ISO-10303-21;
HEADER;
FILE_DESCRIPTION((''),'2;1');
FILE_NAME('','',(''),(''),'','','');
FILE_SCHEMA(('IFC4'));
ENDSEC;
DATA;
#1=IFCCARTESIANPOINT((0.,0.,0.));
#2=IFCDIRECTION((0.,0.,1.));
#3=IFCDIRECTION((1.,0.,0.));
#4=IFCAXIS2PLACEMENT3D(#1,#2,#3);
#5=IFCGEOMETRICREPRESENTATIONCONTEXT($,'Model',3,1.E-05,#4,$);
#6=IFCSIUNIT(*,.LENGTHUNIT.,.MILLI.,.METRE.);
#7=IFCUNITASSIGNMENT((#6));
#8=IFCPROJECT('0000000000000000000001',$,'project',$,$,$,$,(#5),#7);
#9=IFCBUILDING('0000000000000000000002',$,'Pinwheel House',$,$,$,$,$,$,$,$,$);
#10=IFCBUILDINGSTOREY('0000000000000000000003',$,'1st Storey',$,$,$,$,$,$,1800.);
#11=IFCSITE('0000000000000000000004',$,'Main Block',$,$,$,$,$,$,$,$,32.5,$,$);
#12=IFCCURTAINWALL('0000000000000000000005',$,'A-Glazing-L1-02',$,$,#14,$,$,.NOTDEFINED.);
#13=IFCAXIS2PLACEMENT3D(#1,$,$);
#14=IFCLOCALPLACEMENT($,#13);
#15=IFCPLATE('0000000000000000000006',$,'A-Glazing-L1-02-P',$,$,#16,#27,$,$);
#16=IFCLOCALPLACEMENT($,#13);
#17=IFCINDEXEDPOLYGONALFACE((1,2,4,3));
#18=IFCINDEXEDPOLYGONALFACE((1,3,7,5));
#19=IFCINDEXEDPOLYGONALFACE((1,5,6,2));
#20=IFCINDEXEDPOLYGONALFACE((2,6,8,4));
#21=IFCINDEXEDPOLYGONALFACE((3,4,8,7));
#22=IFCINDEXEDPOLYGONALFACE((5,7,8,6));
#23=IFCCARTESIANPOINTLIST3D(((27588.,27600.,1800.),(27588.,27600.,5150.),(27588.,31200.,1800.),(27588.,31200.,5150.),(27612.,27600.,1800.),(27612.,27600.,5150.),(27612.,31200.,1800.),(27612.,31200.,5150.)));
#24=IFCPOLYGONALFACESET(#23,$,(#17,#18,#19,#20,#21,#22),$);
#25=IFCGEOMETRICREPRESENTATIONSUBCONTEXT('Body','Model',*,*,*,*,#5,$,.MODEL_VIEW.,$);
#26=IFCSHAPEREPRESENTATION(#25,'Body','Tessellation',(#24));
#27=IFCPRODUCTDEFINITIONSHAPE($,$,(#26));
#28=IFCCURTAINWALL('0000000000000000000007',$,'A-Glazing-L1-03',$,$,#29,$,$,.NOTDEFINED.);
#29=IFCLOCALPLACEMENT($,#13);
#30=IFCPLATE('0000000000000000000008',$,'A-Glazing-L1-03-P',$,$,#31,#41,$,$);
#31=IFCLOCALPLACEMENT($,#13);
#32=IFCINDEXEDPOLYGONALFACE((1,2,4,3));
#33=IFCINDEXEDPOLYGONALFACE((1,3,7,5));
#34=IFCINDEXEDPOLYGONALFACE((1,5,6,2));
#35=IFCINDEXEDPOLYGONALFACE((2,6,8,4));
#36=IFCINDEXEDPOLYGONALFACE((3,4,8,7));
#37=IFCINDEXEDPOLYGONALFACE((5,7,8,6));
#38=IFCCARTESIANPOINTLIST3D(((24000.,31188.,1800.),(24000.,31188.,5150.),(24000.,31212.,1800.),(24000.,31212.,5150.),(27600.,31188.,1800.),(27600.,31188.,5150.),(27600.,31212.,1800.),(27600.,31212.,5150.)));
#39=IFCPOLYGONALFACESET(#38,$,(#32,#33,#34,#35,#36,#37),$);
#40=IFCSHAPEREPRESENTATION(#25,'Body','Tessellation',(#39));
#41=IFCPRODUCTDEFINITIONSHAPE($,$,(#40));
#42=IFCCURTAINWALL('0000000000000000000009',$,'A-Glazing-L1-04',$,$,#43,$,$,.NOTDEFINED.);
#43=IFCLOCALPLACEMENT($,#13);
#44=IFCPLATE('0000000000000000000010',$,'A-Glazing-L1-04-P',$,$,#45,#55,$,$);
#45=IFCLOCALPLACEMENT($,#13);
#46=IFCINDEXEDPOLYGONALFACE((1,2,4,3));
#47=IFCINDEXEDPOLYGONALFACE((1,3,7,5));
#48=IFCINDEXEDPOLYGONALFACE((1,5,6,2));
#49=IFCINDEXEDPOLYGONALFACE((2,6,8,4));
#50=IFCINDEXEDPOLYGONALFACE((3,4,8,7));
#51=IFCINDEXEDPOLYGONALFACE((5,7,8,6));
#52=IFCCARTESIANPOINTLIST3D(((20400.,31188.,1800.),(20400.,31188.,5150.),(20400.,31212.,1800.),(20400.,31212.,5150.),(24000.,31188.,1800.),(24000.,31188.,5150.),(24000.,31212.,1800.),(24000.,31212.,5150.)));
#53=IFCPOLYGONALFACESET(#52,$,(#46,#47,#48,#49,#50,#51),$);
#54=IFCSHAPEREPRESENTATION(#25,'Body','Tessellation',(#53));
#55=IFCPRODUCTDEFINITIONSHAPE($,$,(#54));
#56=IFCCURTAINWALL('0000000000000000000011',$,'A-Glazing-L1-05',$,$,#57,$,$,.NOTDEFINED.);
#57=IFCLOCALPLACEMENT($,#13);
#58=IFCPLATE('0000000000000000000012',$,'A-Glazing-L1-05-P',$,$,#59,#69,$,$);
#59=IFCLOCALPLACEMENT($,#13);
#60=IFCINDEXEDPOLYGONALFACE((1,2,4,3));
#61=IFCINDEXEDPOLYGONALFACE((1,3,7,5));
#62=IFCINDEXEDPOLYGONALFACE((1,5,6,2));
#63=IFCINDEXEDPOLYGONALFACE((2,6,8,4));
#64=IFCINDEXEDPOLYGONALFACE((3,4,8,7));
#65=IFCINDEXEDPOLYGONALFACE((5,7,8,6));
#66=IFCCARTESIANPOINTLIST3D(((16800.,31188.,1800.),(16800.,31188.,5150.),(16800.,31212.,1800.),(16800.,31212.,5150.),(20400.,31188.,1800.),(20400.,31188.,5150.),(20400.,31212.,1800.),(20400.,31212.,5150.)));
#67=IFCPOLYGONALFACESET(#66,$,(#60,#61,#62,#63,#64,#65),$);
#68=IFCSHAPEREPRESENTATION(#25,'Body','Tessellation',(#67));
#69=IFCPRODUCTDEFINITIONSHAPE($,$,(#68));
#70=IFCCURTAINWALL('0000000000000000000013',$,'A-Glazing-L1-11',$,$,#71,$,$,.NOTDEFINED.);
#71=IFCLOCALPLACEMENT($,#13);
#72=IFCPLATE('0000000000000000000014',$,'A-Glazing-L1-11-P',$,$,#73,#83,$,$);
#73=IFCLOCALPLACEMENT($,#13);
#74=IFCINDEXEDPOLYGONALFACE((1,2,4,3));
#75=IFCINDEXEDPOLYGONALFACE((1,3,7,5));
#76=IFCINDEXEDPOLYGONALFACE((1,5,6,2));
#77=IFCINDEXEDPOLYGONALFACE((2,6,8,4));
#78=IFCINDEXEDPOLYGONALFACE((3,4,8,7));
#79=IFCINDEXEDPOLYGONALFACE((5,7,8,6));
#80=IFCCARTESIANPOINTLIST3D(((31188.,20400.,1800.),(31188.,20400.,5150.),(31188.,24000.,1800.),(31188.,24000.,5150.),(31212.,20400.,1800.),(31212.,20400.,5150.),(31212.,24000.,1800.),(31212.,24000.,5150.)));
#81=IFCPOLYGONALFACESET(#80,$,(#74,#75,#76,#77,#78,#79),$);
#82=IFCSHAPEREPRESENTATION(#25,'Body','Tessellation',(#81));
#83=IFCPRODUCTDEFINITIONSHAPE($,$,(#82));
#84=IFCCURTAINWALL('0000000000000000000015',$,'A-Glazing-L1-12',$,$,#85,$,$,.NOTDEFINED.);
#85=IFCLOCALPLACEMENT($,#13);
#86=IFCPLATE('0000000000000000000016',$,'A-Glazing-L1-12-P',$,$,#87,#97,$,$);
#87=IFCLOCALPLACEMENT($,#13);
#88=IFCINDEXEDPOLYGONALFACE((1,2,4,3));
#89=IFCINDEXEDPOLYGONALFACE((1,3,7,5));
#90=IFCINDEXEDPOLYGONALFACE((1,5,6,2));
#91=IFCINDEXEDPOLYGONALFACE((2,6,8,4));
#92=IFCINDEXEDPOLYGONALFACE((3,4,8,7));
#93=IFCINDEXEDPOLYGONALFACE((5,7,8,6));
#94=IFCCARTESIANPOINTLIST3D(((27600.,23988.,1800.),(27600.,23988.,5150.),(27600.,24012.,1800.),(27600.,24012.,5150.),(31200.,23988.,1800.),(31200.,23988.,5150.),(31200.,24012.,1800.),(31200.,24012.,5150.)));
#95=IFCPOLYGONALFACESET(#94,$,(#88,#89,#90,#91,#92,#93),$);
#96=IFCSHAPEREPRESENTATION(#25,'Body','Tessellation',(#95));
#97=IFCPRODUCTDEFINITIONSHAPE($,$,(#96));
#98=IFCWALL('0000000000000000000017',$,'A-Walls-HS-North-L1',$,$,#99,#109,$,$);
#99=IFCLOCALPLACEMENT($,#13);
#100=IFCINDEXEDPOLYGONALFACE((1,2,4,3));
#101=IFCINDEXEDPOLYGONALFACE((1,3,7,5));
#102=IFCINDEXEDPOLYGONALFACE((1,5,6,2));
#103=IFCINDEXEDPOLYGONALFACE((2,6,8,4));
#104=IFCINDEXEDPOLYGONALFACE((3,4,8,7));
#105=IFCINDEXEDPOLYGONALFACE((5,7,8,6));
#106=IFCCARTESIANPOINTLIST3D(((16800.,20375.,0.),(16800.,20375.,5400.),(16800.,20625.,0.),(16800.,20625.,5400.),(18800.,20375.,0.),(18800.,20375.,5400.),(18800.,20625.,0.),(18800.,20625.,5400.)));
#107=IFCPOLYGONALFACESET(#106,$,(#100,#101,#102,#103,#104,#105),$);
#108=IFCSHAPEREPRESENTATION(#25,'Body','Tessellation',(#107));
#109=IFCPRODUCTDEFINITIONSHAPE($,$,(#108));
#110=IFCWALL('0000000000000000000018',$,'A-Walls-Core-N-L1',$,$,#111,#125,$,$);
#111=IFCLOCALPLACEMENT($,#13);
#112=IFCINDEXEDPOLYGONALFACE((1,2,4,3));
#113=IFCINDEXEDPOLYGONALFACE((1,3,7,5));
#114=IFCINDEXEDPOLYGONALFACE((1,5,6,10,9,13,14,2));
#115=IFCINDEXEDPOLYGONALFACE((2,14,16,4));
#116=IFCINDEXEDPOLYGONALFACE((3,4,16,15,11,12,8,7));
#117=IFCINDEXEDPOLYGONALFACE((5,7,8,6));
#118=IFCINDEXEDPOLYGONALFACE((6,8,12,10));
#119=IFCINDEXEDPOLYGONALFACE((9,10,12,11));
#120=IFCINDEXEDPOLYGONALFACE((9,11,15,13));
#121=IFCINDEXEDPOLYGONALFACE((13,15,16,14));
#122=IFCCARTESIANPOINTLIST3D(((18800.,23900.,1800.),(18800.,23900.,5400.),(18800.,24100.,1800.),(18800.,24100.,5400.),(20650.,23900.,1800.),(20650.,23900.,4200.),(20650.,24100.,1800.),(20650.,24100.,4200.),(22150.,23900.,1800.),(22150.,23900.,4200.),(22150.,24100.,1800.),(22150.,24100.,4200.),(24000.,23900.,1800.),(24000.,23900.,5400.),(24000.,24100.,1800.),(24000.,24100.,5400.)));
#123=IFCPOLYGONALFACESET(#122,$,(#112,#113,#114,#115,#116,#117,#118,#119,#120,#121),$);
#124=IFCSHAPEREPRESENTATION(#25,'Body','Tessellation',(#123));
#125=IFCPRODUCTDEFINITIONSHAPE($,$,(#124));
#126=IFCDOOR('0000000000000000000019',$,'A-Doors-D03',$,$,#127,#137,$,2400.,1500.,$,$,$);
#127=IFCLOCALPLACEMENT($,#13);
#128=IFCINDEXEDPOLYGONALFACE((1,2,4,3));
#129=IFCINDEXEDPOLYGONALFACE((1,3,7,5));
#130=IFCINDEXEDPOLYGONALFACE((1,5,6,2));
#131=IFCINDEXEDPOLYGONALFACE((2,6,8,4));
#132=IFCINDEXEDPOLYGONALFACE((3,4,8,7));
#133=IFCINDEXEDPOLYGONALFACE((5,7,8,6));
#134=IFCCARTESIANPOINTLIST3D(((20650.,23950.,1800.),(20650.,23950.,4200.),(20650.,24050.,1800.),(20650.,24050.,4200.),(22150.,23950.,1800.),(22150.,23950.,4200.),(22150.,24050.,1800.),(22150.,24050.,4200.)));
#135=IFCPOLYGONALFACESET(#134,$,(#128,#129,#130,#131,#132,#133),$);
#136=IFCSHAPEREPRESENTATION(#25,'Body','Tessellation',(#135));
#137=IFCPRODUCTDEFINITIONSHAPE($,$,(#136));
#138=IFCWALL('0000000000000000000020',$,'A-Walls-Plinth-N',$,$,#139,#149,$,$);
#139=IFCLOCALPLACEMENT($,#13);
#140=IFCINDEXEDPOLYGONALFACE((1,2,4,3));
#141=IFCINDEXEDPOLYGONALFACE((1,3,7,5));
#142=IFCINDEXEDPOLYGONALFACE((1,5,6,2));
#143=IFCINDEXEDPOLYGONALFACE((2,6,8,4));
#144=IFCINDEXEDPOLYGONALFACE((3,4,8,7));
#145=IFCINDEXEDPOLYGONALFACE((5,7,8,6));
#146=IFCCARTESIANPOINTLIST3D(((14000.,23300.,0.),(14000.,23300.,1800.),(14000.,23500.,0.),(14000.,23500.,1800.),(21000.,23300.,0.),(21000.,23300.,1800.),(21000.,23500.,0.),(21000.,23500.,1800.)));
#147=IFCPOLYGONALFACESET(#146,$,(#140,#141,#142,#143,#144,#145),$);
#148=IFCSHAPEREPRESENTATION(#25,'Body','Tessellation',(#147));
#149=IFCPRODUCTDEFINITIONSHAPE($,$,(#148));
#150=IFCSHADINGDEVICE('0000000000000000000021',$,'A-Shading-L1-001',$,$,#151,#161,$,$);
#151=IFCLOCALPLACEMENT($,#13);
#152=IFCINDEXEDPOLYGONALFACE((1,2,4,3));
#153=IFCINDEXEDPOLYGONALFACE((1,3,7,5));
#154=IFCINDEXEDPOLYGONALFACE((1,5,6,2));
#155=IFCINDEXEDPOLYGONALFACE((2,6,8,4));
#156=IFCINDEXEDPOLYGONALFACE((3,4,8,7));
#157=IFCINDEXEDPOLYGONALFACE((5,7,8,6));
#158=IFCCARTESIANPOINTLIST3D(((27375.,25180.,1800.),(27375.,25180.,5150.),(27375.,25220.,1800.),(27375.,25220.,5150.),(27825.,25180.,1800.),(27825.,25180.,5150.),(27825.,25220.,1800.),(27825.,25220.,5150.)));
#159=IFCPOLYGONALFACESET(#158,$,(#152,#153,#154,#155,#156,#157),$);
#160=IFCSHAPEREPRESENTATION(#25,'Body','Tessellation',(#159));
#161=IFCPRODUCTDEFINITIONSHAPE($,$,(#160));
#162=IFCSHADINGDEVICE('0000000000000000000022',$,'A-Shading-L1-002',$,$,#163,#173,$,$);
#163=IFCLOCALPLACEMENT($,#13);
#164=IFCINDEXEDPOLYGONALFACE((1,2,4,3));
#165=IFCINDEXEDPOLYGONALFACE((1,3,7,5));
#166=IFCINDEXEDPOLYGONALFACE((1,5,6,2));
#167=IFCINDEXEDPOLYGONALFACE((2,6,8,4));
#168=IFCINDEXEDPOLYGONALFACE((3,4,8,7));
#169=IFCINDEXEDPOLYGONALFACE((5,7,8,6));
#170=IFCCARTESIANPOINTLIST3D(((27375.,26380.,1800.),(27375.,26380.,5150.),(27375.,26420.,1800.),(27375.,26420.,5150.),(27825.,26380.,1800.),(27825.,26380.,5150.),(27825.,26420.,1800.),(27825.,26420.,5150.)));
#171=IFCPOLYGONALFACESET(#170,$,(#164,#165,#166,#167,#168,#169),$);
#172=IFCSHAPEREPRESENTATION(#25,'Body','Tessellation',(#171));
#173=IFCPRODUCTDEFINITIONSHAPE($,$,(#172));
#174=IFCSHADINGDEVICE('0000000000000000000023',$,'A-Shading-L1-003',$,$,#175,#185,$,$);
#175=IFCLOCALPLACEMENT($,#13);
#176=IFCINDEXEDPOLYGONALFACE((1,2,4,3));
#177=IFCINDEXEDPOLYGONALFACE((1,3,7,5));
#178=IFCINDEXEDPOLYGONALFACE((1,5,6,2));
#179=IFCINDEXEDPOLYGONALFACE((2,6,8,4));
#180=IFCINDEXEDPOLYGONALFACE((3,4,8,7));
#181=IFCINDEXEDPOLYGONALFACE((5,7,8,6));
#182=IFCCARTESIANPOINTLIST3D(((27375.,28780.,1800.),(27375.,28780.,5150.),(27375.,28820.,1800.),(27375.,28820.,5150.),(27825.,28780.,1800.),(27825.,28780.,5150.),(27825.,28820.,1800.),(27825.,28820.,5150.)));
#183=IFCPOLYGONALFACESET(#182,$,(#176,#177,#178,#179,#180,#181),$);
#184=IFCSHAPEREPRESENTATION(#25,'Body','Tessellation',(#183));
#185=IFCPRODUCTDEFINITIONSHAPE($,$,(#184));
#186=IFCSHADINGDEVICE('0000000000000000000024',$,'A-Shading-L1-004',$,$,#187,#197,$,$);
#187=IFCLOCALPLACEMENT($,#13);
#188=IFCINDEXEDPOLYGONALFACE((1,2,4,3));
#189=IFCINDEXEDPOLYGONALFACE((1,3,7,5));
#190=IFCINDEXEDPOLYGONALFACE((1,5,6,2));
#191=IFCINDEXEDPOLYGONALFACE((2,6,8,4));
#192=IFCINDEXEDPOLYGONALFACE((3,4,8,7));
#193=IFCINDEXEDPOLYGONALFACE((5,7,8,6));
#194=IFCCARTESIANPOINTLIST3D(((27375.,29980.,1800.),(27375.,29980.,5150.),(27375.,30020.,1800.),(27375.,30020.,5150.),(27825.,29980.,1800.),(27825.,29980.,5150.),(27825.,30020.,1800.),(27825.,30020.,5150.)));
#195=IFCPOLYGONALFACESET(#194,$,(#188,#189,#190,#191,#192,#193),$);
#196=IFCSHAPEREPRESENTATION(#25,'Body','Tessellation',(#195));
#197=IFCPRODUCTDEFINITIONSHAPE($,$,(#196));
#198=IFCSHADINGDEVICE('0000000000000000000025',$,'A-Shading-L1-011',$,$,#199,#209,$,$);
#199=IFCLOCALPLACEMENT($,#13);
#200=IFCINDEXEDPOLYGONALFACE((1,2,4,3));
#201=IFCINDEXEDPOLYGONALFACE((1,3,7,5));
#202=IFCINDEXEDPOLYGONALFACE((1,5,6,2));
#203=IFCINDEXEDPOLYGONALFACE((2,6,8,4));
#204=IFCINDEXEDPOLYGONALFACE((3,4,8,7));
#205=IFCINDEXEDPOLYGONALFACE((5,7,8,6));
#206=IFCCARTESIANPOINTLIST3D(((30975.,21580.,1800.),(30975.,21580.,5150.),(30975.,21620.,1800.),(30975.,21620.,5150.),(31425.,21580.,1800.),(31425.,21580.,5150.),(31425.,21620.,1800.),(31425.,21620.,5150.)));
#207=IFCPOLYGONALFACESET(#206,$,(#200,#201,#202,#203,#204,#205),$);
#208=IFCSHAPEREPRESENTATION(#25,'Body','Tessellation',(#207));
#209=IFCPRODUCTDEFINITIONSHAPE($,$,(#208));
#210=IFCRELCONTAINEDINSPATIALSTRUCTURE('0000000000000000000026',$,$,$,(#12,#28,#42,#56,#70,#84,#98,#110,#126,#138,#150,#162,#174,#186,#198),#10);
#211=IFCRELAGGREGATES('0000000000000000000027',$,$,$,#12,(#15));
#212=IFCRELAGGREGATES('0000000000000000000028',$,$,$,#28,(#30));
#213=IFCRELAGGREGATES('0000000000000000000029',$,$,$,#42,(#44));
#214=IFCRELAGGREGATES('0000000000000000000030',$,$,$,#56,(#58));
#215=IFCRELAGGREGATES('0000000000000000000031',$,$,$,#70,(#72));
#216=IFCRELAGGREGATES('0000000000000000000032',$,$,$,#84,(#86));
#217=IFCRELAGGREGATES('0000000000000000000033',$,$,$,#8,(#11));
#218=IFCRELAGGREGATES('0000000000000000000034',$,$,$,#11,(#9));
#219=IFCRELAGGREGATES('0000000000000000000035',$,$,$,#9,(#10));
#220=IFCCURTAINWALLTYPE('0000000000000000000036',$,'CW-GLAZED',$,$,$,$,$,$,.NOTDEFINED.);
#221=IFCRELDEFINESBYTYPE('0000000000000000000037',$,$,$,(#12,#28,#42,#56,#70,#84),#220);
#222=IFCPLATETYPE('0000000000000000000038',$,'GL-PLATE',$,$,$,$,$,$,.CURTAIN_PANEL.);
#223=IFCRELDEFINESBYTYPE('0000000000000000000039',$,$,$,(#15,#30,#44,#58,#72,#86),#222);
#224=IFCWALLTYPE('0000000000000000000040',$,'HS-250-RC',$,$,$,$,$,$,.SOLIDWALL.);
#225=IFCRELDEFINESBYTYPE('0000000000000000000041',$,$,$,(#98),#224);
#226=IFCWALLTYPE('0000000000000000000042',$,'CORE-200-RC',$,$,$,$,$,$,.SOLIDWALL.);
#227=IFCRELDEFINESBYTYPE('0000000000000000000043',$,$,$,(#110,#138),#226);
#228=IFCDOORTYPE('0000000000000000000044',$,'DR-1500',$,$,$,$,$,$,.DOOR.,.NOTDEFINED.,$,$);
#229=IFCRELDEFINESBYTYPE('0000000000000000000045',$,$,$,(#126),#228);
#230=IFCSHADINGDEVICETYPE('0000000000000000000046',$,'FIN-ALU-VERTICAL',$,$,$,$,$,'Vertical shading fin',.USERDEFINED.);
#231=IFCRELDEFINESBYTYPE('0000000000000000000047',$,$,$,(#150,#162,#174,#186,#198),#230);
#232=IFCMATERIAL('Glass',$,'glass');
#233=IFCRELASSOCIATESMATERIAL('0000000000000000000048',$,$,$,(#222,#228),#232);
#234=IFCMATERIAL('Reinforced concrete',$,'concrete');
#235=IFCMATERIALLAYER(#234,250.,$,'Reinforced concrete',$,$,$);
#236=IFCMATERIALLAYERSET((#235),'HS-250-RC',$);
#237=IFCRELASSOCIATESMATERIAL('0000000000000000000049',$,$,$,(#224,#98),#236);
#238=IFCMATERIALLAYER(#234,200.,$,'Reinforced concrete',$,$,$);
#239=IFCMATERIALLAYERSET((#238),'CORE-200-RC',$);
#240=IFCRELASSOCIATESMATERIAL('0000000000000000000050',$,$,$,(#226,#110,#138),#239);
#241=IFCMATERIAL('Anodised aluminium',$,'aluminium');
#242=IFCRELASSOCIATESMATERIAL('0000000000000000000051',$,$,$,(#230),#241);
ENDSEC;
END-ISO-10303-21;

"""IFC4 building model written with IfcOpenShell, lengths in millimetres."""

from ifc_helpers import new_model, si_unit, frame, origin_with_axes, place, context, subcontext, project, spatial, indexed_curve, outline, extrude, material, layer, layer_set, layer_usage, type_object, element, fill, aggregate, save


model = new_model("IFC4")

# Units and contexts
model_context = context("Model", 3, precision=1e-05, world=origin_with_axes())
body_context = subcontext(model_context, "Body", "Model", "MODEL_VIEW")
ifc_project = project(units=[si_unit("LENGTHUNIT", "METRE", prefix="MILLI")], contexts=[model_context])

# Site, building, storey
site = spatial("IfcSite", under=ifc_project, Name="Main Block", RefElevation=32.5)
building = spatial("IfcBuilding", under=site, Name="Pinwheel House")
storey = spatial("IfcBuildingStorey", under=building, Name="1st Storey", Elevation=1800.0)

# Shared definitions
ifc_material_1 = material(Name="Anodised aluminium", Category="aluminium")

# Curtain walls, plates
curtain_wall_type = type_object("IfcCurtainWallType", Name="CW-GLAZED", PredefinedType="NOTDEFINED")
ifc_material_2 = material(Name="Glass", Category="glass")
plate_type = type_object("IfcPlateType", Name="GL-PLATE", PredefinedType="CURTAIN_PANEL", material=ifc_material_2)
curtain_wall_1 = element("IfcCurtainWall", 1, inside=storey, type_object=curtain_wall_type, Name="A-Glazing-L1-02", PredefinedType="NOTDEFINED")
plate_1_placement = place(None, frame((27600.0, 29400.0, 1800.0), z_axis=(0.0, 0.0, 1.0), x_axis=(0.0, 1.0, 0.0)))
plate_1 = element("IfcPlate", 2, at=plate_1_placement, type_object=plate_type, Name="A-Glazing-L1-02-P", context=body_context, shape_type="SweptSolid", body=[
    extrude(outline(indexed_curve([(-1800.0, -12.0), (1800.0, -12.0), (1800.0, 12.0), (-1800.0, 12.0)])), None, (0.0, 0.0, 1.0), 3350.0),
])
aggregate(curtain_wall_1, [plate_1])
curtain_wall_2 = element("IfcCurtainWall", 3, inside=storey, type_object=curtain_wall_type, Name="A-Glazing-L1-03", PredefinedType="NOTDEFINED")
plate_2_placement = place(None, frame((25800.0, 31200.0, 1800.0), z_axis=(0.0, 0.0, 1.0), x_axis=(-1.0, 0.0, 0.0)))
plate_2 = element("IfcPlate", 4, at=plate_2_placement, type_object=plate_type, Name="A-Glazing-L1-03-P", context=body_context, shape_type="SweptSolid", body=[
    extrude(outline(indexed_curve([(-1800.0, -12.0), (1800.0, -12.0), (1800.0, 12.0), (-1800.0, 12.0)])), None, (0.0, 0.0, 1.0), 3350.0),
])
aggregate(curtain_wall_2, [plate_2])
curtain_wall_3 = element("IfcCurtainWall", 5, inside=storey, type_object=curtain_wall_type, Name="A-Glazing-L1-04", PredefinedType="NOTDEFINED")
plate_3_placement = place(None, frame((22200.0, 31200.0, 1800.0), z_axis=(0.0, 0.0, 1.0), x_axis=(-1.0, 0.0, 0.0)))
plate_3 = element("IfcPlate", 6, at=plate_3_placement, type_object=plate_type, Name="A-Glazing-L1-04-P", context=body_context, shape_type="SweptSolid", body=[
    extrude(outline(indexed_curve([(-1800.0, -12.0), (1800.0, -12.0), (1800.0, 12.0), (-1800.0, 12.0)])), None, (0.0, 0.0, 1.0), 3350.0),
])
aggregate(curtain_wall_3, [plate_3])
curtain_wall_4 = element("IfcCurtainWall", 7, inside=storey, type_object=curtain_wall_type, Name="A-Glazing-L1-05", PredefinedType="NOTDEFINED")
plate_4_placement = place(None, frame((18600.0, 31200.0, 1800.0), z_axis=(0.0, 0.0, 1.0), x_axis=(-1.0, 0.0, 0.0)))
plate_4 = element("IfcPlate", 8, at=plate_4_placement, type_object=plate_type, Name="A-Glazing-L1-05-P", context=body_context, shape_type="SweptSolid", body=[
    extrude(outline(indexed_curve([(-1800.0, -12.0), (1800.0, -12.0), (1800.0, 12.0), (-1800.0, 12.0)])), None, (0.0, 0.0, 1.0), 3350.0),
])
aggregate(curtain_wall_4, [plate_4])
curtain_wall_5 = element("IfcCurtainWall", 9, inside=storey, type_object=curtain_wall_type, Name="A-Glazing-L1-11", PredefinedType="NOTDEFINED")
plate_5_placement = place(None, frame((31200.0, 22200.0, 1800.0), z_axis=(0.0, 0.0, 1.0), x_axis=(0.0, 1.0, 0.0)))
plate_5 = element("IfcPlate", 10, at=plate_5_placement, type_object=plate_type, Name="A-Glazing-L1-11-P", context=body_context, shape_type="SweptSolid", body=[
    extrude(outline(indexed_curve([(-1800.0, -12.0), (1800.0, -12.0), (1800.0, 12.0), (-1800.0, 12.0)])), None, (0.0, 0.0, 1.0), 3350.0),
])
aggregate(curtain_wall_5, [plate_5])
curtain_wall_6 = element("IfcCurtainWall", 11, inside=storey, type_object=curtain_wall_type, Name="A-Glazing-L1-12", PredefinedType="NOTDEFINED")
plate_6_placement = place(None, frame((29400.0, 24000.0, 1800.0), z_axis=(0.0, 0.0, 1.0), x_axis=(-1.0, 0.0, 0.0)))
plate_6 = element("IfcPlate", 12, at=plate_6_placement, type_object=plate_type, Name="A-Glazing-L1-12-P", context=body_context, shape_type="SweptSolid", body=[
    extrude(outline(indexed_curve([(-1800.0, -12.0), (1800.0, -12.0), (1800.0, 12.0), (-1800.0, 12.0)])), None, (0.0, 0.0, 1.0), 3350.0),
])
aggregate(curtain_wall_6, [plate_6])

# Wall
ifc_material_3 = material(Name="Reinforced concrete", Category="concrete")
ifc_layer_1 = layer(ifc_material_3, 250.0, Name="Reinforced concrete")
ifc_layer_set_1 = layer_set([ifc_layer_1], Name="HS-250-RC")
ifc_layer_usage_1 = layer_usage(ifc_layer_set_1, "AXIS2", "POSITIVE", 0.0)
wall_type_1 = type_object("IfcWallType", Name="HS-250-RC", PredefinedType="SOLIDWALL", material=ifc_layer_set_1)
wall_1_placement = place(None, frame((18800.0, 20625.0, 0.0), z_axis=(0.0, 0.0, 1.0), x_axis=(-1.0, 0.0, 0.0)))
element("IfcWall", 13, at=wall_1_placement, inside=storey, type_object=wall_type_1, material=ifc_layer_usage_1, Name="A-Walls-HS-North-L1", context=body_context, shape_type="SweptSolid", body=[
    extrude(outline(indexed_curve([(0.0, 0.0), (0.0, 250.0), (2000.0, 250.0), (2000.0, 0.0), (0.0, 0.0)], self_intersect=False)), origin_with_axes(), (0.0, 0.0, 1.0), 5400.0),
])

# Wall, opening, door
ifc_layer_2 = layer(ifc_material_3, 200.0, Name="Reinforced concrete")
ifc_layer_set_2 = layer_set([ifc_layer_2], Name="CORE-200-RC")
ifc_layer_usage_2 = layer_usage(ifc_layer_set_2, "AXIS2", "POSITIVE", 0.0)
wall_type_2 = type_object("IfcWallType", Name="CORE-200-RC", PredefinedType="SOLIDWALL", material=ifc_layer_set_2)
wall_2_placement = place(None, frame((18800.0, 23900.0, 1800.0), z_axis=(0.0, 0.0, 1.0), x_axis=(1.0, 0.0, 0.0)))
wall_2 = element("IfcWall", 14, at=wall_2_placement, inside=storey, type_object=wall_type_2, material=ifc_layer_usage_2, Name="A-Walls-Core-N-L1", context=body_context, shape_type="SweptSolid", body=[
    extrude(outline(indexed_curve([(0.0, 0.0), (0.0, 200.0), (5200.0, 200.0), (5200.0, 0.0), (0.0, 0.0)], self_intersect=False)), origin_with_axes(), (0.0, 0.0, 1.0), 3600.0),
])
opening_placement = place(wall_2_placement, frame((2600.0, 100.0, 0.0), z_axis=(0.0, 0.0, 1.0), x_axis=(1.0, 0.0, 0.0)))
opening = element("IfcOpeningElement", 15, at=opening_placement, cuts=wall_2, PredefinedType="OPENING", context=body_context, shape_type="SweptSolid", body=[
    extrude(outline(indexed_curve([(-750.0, -150.0), (750.0, -150.0), (750.0, 150.0), (-750.0, 150.0)])), None, (0.0, 0.0, 1.0), 2400.0),
])
door_type = type_object("IfcDoorType", Name="DR-1500", OperationType="NOTDEFINED", PredefinedType="DOOR", material=ifc_material_2)
door_placement = place(None, frame((21400.0, 24000.0, 1800.0), z_axis=(0.0, 0.0, 1.0), x_axis=(1.0, 0.0, 0.0)))
door = element("IfcDoor", 16, at=door_placement, inside=storey, type_object=door_type, Name="A-Doors-D03", OverallHeight=2400.0, OverallWidth=1500.0, context=body_context, shape_type="SweptSolid", body=[
    extrude(outline(indexed_curve([(-750.0, -50.0), (750.0, -50.0), (750.0, 50.0), (-750.0, 50.0)])), None, (0.0, 0.0, 1.0), 2400.0),
])
fill(opening, door)

# Wall
ifc_layer_usage_3 = layer_usage(ifc_layer_set_2, "AXIS2", "POSITIVE", 0.0)
wall_3_placement = place(None, frame((21000.0, 23500.0, 0.0), z_axis=(0.0, 0.0, 1.0), x_axis=(-1.0, 0.0, 0.0)))
element("IfcWall", 17, at=wall_3_placement, inside=storey, type_object=wall_type_2, material=ifc_layer_usage_3, Name="A-Walls-Plinth-N", context=body_context, shape_type="SweptSolid", body=[
    extrude(outline(indexed_curve([(0.0, 0.0), (0.0, 200.0), (7000.0, 200.0), (7000.0, 0.0), (0.0, 0.0)], self_intersect=False)), origin_with_axes(), (0.0, 0.0, 1.0), 1800.0),
])

# Shading devices
shading_device_type = type_object("IfcShadingDeviceType", Name="FIN-ALU-VERTICAL", ElementType="Vertical shading fin", PredefinedType="USERDEFINED", material=ifc_material_1)
for number, where, z_axis, x_axis, name in (
    (18, (27600.0, 25200.0, 1800.0), (0.0, 0.0, 1.0), (0.0, 1.0, 0.0), "A-Shading-L1-001"),
    (19, (27600.0, 26400.0, 1800.0), (0.0, 0.0, 1.0), (0.0, 1.0, 0.0), "A-Shading-L1-002"),
    (20, (27600.0, 28800.0, 1800.0), (0.0, 0.0, 1.0), (0.0, 1.0, 0.0), "A-Shading-L1-003"),
    (21, (27600.0, 30000.0, 1800.0), (0.0, 0.0, 1.0), (0.0, 1.0, 0.0), "A-Shading-L1-004"),
    (22, (31200.0, 21600.0, 1800.0), (0.0, 0.0, 1.0), (0.0, 1.0, 0.0), "A-Shading-L1-011"),
):
    element("IfcShadingDevice", number, at=place(None, frame(where, z_axis=z_axis, x_axis=x_axis)), inside=storey, type_object=shading_device_type, Name=name, context=body_context, shape_type="SweptSolid", body=[
        extrude(outline(indexed_curve([(-20.0, -225.0), (20.0, -225.0), (20.0, 225.0), (-20.0, 225.0)])), None, (0.0, 0.0, 1.0), 3350.0),
    ])

save(model, "model.ifc")
